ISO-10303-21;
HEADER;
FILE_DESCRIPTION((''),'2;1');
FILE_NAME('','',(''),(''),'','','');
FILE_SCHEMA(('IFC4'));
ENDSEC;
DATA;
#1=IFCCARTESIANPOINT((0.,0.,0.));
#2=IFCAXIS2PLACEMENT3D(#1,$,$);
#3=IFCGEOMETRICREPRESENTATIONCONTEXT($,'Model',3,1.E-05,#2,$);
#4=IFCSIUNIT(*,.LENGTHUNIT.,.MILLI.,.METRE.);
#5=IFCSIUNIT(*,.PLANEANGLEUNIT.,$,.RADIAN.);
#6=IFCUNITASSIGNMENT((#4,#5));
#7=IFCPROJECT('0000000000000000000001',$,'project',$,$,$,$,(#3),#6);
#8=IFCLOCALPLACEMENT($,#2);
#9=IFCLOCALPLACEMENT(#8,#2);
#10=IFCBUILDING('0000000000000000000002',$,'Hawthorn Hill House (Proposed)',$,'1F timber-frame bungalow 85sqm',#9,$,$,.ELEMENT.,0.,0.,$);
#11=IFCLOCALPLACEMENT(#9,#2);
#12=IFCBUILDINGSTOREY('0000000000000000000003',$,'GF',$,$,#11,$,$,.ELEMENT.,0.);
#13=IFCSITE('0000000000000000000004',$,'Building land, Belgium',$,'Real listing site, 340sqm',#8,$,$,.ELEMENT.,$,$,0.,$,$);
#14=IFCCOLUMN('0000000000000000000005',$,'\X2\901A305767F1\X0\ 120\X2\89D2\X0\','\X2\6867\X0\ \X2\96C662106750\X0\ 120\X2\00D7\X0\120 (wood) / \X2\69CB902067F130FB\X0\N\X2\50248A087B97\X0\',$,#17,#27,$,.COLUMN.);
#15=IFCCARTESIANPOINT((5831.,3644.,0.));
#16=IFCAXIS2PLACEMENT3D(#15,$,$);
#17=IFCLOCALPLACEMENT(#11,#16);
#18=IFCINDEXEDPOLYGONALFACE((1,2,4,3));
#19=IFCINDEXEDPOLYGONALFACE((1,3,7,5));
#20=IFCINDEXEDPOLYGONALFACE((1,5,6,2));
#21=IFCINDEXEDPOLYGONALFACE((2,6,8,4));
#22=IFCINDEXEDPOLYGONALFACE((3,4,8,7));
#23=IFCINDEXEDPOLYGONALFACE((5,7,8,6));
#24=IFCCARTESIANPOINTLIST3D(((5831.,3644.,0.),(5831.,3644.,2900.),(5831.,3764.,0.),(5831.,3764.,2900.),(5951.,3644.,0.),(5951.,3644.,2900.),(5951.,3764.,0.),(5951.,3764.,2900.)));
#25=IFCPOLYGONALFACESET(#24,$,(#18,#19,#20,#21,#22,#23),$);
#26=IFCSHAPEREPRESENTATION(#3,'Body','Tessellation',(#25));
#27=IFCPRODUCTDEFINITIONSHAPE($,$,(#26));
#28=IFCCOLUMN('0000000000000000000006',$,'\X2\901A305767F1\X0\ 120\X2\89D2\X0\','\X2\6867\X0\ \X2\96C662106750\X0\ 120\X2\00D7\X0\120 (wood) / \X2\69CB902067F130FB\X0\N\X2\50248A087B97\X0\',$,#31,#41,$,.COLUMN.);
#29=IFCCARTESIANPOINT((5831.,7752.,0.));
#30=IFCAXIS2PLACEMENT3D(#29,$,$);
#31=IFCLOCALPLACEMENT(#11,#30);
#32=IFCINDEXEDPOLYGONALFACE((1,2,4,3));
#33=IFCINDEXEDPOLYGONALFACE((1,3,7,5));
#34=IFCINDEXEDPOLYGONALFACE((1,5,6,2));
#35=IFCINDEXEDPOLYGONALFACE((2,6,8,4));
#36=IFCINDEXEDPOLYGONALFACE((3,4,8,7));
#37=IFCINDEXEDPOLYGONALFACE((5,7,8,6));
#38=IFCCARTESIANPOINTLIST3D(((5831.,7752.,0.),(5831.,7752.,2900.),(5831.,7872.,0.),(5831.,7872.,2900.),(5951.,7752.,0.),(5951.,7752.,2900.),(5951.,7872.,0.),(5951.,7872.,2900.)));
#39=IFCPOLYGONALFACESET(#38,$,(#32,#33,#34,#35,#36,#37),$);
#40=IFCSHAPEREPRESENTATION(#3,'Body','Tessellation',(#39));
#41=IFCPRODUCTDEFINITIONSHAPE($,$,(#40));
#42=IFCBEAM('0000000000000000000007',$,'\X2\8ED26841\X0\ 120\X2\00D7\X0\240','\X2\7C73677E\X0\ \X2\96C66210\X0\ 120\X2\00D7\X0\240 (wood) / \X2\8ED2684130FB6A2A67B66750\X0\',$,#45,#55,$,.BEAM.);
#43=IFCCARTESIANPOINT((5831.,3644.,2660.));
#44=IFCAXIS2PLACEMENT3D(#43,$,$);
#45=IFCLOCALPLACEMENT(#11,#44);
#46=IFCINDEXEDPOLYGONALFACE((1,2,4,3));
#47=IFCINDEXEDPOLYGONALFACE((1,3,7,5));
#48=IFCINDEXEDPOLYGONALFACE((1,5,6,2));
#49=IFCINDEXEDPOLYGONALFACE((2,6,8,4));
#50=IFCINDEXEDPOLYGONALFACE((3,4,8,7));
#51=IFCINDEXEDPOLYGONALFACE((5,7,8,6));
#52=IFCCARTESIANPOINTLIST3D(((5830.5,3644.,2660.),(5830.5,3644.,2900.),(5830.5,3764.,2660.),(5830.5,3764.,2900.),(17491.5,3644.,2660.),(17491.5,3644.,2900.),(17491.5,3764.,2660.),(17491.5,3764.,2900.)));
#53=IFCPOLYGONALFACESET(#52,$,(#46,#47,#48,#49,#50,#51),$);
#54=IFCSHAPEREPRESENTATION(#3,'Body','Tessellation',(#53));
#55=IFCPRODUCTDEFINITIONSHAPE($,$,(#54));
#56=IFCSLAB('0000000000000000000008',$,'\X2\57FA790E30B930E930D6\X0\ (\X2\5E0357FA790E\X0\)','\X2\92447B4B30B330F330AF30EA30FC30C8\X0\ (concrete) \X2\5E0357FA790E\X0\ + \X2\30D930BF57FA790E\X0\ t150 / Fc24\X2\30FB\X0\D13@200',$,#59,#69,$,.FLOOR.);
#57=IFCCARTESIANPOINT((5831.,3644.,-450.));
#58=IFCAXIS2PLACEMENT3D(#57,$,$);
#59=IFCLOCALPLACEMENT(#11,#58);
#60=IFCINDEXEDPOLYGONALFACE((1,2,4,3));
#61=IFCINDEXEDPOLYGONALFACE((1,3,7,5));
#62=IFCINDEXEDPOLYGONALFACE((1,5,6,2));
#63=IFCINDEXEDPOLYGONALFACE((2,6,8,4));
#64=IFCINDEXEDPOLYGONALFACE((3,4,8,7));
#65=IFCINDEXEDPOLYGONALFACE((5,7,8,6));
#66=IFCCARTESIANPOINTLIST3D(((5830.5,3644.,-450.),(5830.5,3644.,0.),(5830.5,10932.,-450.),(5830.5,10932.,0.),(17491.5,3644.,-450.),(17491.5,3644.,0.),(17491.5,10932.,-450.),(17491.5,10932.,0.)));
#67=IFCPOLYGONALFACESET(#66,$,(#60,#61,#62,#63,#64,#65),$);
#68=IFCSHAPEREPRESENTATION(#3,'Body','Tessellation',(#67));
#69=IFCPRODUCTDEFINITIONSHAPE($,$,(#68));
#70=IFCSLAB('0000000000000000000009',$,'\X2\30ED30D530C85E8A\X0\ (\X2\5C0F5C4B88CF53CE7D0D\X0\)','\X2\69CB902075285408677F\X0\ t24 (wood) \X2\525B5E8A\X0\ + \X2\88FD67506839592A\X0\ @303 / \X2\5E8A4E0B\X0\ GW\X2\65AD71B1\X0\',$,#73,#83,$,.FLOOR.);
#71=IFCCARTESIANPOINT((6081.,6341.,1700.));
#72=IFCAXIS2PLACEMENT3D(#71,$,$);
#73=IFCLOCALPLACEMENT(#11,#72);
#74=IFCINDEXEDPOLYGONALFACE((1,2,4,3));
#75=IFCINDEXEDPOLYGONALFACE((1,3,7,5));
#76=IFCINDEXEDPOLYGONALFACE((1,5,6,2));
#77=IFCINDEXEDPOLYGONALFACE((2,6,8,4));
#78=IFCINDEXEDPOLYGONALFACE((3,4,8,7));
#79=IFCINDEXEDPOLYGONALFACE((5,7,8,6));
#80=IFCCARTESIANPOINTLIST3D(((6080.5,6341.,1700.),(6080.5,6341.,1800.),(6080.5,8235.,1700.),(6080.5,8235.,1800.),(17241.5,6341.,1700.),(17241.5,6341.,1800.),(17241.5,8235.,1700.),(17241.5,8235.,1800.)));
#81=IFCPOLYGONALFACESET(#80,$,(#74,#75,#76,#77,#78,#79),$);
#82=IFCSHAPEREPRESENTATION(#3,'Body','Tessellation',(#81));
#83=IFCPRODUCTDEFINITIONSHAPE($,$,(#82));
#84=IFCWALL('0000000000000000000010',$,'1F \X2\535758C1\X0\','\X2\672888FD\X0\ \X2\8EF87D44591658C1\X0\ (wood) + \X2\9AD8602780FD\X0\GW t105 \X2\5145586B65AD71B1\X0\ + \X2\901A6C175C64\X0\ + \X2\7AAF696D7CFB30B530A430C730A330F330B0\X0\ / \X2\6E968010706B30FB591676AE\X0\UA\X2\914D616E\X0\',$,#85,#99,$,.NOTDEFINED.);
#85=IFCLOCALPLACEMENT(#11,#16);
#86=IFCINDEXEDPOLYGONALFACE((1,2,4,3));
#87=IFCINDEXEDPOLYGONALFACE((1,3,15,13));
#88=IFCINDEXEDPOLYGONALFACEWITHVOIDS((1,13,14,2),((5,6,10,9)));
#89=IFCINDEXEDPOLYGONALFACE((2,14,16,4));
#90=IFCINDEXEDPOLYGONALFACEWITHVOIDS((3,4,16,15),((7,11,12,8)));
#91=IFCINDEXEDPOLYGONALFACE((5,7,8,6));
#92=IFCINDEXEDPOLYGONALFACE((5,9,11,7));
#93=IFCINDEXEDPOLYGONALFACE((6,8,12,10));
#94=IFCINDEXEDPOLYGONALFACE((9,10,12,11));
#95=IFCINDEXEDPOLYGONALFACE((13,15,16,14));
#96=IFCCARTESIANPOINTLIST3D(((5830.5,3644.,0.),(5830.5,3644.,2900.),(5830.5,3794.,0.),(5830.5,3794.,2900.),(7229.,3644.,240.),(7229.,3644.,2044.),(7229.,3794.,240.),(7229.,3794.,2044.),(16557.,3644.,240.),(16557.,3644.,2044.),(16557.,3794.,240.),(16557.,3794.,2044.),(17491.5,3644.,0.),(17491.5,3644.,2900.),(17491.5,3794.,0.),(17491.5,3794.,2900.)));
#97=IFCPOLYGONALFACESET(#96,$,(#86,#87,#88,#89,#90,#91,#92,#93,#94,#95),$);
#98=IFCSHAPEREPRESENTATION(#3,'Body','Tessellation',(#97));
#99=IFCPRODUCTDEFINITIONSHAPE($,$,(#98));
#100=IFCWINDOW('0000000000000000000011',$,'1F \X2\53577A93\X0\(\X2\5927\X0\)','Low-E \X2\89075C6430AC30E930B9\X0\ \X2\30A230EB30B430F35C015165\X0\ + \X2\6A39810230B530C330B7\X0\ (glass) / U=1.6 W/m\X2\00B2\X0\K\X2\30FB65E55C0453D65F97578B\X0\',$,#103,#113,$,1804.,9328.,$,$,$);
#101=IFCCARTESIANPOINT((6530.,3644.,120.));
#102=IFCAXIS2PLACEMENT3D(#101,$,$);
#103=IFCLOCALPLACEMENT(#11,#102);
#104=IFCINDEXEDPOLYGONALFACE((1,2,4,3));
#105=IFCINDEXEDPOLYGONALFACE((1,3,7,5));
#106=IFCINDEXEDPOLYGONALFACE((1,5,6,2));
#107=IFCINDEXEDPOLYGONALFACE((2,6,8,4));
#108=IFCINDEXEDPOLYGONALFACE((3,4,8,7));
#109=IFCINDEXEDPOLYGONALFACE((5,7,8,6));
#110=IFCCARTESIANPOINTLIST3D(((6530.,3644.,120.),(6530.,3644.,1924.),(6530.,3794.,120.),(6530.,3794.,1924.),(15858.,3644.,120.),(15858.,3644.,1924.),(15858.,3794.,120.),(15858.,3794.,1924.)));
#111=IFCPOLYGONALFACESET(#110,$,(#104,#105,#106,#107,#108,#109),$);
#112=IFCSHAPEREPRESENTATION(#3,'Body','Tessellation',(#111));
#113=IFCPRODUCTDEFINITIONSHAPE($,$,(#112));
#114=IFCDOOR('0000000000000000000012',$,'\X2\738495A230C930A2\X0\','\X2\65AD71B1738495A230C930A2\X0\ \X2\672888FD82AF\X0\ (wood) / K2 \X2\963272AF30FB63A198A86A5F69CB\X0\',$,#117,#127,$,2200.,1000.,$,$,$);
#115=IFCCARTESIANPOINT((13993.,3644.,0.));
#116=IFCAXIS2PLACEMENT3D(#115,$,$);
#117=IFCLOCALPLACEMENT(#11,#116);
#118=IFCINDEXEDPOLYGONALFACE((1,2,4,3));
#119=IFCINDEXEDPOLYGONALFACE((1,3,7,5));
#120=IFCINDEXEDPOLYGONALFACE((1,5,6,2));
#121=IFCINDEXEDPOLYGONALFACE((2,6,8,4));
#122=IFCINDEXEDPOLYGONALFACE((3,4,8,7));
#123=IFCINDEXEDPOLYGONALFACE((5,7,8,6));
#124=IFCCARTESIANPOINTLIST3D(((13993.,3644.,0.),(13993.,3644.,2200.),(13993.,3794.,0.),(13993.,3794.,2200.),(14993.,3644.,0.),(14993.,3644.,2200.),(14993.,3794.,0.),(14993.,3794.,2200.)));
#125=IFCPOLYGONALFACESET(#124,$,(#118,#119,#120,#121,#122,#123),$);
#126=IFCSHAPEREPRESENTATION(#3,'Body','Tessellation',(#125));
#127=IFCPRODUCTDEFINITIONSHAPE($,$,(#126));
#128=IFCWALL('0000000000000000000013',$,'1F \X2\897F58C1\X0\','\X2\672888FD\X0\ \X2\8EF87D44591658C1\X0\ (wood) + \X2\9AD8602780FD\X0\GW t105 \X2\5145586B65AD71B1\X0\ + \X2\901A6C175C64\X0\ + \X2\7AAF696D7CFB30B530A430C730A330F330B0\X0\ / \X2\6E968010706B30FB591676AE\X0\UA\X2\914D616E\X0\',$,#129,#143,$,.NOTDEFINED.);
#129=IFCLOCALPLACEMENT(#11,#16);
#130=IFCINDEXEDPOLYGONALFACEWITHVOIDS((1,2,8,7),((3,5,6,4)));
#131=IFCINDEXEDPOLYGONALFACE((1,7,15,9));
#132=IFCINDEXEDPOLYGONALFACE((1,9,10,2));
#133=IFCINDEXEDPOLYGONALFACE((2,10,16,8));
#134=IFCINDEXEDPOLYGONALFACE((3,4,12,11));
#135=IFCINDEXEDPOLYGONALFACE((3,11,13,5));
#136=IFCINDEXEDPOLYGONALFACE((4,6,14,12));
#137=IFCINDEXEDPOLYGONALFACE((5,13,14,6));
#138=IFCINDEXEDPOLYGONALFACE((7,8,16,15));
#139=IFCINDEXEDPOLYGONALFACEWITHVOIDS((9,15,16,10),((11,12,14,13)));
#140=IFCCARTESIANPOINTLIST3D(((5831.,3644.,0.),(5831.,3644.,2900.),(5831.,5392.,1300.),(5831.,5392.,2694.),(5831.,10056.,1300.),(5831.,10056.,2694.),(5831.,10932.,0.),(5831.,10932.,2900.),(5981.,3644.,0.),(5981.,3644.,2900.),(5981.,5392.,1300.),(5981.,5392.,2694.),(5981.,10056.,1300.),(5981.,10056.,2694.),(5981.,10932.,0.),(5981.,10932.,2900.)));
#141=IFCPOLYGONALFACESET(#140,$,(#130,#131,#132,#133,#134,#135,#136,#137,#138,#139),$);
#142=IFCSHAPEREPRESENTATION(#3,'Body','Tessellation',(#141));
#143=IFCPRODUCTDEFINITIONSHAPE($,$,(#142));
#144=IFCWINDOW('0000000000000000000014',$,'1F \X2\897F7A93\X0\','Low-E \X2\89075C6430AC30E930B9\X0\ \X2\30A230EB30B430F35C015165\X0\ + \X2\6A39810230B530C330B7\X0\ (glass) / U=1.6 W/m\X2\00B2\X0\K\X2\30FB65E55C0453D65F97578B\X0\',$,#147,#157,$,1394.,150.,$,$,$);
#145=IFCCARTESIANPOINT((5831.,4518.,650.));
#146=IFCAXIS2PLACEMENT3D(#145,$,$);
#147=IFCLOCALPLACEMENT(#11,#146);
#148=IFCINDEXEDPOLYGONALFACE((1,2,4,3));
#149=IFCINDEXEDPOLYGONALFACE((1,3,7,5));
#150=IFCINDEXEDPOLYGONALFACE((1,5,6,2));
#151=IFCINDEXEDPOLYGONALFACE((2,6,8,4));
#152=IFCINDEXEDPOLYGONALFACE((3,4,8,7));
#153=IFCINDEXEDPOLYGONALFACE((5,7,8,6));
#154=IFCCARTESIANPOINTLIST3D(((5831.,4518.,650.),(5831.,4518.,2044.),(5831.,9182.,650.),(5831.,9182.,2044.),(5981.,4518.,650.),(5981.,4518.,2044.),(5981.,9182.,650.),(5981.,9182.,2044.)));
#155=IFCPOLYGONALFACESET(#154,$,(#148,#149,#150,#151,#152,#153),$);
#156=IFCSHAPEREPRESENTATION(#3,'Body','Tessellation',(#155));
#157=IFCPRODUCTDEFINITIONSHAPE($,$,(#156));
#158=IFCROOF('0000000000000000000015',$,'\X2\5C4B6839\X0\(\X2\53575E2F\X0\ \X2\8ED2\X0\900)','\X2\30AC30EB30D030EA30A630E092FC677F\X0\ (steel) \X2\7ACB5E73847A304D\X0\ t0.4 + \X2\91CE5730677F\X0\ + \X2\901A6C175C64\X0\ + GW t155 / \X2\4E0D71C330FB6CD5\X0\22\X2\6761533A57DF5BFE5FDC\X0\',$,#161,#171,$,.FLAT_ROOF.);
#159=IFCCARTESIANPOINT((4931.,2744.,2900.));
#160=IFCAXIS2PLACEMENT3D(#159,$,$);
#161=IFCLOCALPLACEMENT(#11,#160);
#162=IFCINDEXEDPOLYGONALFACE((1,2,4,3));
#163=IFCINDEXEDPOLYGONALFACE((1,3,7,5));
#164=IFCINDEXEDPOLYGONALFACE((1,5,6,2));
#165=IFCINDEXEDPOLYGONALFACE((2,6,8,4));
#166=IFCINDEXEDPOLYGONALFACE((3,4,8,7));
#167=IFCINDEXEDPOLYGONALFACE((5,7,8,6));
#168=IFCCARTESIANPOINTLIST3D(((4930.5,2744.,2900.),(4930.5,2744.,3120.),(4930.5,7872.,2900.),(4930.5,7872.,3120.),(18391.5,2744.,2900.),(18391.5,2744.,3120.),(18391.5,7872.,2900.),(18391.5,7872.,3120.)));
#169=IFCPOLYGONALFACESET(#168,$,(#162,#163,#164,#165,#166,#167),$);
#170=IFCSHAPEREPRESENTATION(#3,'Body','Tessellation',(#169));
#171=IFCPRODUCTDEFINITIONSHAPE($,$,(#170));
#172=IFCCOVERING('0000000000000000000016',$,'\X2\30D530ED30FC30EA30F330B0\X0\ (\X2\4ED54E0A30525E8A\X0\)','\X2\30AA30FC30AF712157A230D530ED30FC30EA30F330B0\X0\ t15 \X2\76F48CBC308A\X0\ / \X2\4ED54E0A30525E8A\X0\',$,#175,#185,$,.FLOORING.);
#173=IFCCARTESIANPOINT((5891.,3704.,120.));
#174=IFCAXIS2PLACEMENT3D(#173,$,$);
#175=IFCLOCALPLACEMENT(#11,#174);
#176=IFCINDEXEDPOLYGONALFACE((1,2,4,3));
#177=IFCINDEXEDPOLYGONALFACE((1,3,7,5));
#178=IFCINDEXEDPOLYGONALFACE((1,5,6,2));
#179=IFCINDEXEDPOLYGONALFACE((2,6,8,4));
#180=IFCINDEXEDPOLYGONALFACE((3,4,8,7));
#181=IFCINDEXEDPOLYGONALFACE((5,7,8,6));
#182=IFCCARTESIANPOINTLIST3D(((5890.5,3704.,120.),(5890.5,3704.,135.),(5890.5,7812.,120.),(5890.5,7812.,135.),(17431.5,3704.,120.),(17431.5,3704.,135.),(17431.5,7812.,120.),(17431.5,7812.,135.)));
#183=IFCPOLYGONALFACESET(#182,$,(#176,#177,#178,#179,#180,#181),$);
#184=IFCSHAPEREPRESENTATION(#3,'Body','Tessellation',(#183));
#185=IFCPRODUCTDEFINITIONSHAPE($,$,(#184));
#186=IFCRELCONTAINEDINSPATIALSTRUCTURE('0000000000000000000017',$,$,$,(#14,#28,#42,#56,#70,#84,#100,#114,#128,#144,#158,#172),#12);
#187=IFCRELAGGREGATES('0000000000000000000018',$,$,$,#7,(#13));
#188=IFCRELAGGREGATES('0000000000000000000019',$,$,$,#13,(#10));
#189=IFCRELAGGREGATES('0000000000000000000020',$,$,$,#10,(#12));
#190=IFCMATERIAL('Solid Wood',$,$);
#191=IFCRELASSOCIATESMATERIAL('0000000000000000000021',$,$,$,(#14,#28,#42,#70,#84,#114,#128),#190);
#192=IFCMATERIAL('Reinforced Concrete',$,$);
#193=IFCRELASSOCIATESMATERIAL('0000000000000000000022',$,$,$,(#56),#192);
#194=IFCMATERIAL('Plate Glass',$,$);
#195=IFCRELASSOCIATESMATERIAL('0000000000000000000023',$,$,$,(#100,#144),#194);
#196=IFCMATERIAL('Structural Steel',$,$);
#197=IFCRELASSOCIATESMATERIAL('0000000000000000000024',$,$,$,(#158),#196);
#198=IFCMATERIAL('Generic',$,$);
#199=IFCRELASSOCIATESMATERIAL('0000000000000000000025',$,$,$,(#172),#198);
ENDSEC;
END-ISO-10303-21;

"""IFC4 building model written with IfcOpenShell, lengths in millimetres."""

from ifc_helpers import new_model, si_unit, frame, frame_2d, origin, place, context, project, spatial, rectangle, extrude, material, element, fill, save


model = new_model("IFC4")

# Units and contexts
model_context = context("Model", 3, precision=1e-05, world=origin())
ifc_project = project(units=[si_unit("LENGTHUNIT", "METRE", prefix="MILLI"), si_unit("PLANEANGLEUNIT", "RADIAN")], contexts=[model_context])

# Site, building, storey
site_placement = place(None, origin())
site = spatial("IfcSite", under=ifc_project, at=site_placement, Name="Building land, Belgium", ObjectType="Real listing site, 340sqm", CompositionType="ELEMENT", RefElevation=0.0)
building_placement = place(site_placement, origin())
building = spatial("IfcBuilding", under=site, at=building_placement, Name="Hawthorn Hill House (Proposed)", ObjectType="1F timber-frame bungalow 85sqm", CompositionType="ELEMENT", ElevationOfRefHeight=0.0, ElevationOfTerrain=0.0)
storey_placement = place(building_placement, origin())
storey = spatial("IfcBuildingStorey", under=building, at=storey_placement, Name="GF", CompositionType="ELEMENT", Elevation=0.0)

# Columns
ifc_material_1 = material(Name="Solid Wood")
column_1_placement = place(storey_placement, frame((5831.0, 3644.0, 0.0)))
element("IfcColumn", 1, at=column_1_placement, inside=storey, material=ifc_material_1, Name="通し柱 120角", Description="桧 集成材 120×120 (wood) / 構造柱・N値計算", PredefinedType="COLUMN", context=model_context, shape_type="SweptSolid", body=[
    extrude(rectangle(XDim=120.0, YDim=120.0, at=frame_2d((60.0, 60.0))), frame((5831.0, 3644.0, 0.0)), (0.0, 0.0, 1.0), 2900.0),
])
column_2_placement = place(storey_placement, frame((5831.0, 7752.0, 0.0)))
element("IfcColumn", 2, at=column_2_placement, inside=storey, material=ifc_material_1, Name="通し柱 120角", Description="桧 集成材 120×120 (wood) / 構造柱・N値計算", PredefinedType="COLUMN", context=model_context, shape_type="SweptSolid", body=[
    extrude(rectangle(XDim=120.0, YDim=120.0, at=frame_2d((60.0, 60.0))), frame((5831.0, 7752.0, 0.0)), (0.0, 0.0, 1.0), 2900.0),
])

# Beam
beam_1_placement = place(storey_placement, frame((5831.0, 3644.0, 2660.0)))
element("IfcBeam", 3, at=beam_1_placement, inside=storey, material=ifc_material_1, Name="軒桁 120×240", Description="米松 集成 120×240 (wood) / 軒桁・横架材", PredefinedType="BEAM", context=model_context, shape_type="SweptSolid", body=[
    extrude(rectangle(XDim=11661.0, YDim=120.0, at=frame_2d((5830.0, 60.0))), frame((5831.0, 3644.0, 2660.0)), (0.0, 0.0, 1.0), 240.0),
])

# Slabs
ifc_material_2 = material(Name="Reinforced Concrete")
slab_1_placement = place(storey_placement, frame((5831.0, 3644.0, -450.0)))
element("IfcSlab", 4, at=slab_1_placement, inside=storey, material=ifc_material_2, Name="基礎スラブ (布基礎)", Description="鉄筋コンクリート (concrete) 布基礎 + ベタ基礎 t150 / Fc24・D13@200", PredefinedType="FLOOR", context=model_context, shape_type="SweptSolid", body=[
    extrude(rectangle(XDim=11661.0, YDim=7288.0, at=frame_2d((5830.0, 3644.0))), frame((5831.0, 3644.0, -450.0)), (0.0, 0.0, 1.0), 450.0),
])
slab_2_placement = place(storey_placement, frame((6081.0, 6341.0, 1700.0)))
element("IfcSlab", 5, at=slab_2_placement, inside=storey, material=ifc_material_1, Name="ロフト床 (小屋裏収納)", Description="構造用合板 t24 (wood) 剛床 + 製材根太 @303 / 床下 GW断熱", PredefinedType="FLOOR", context=model_context, shape_type="SweptSolid", body=[
    extrude(rectangle(XDim=11161.0, YDim=1894.0, at=frame_2d((5580.0, 947.0))), frame((6081.0, 6341.0, 1700.0)), (0.0, 0.0, 1.0), 100.0),
])

# Wall, openings, window, door
wall_1_placement = place(storey_placement, frame((5831.0, 3644.0, 0.0)))
wall_1 = element("IfcWall", 6, at=wall_1_placement, inside=storey, material=ifc_material_1, Name="1F 南壁", Description="木製 軸組外壁 (wood) + 高性能GW t105 充填断熱 + 通気層 + 窯業系サイディング / 準耐火・外皮UA配慮", PredefinedType="NOTDEFINED", context=model_context, shape_type="SweptSolid", body=[
    extrude(rectangle(XDim=11661.0, YDim=150.0, at=frame_2d((5830.0, 75.0))), frame((5831.0, 3644.0, 0.0)), (0.0, 0.0, 1.0), 2900.0),
])
opening_1_placement = place(storey_placement, frame((6530.0, 3644.0, 120.0)))
opening_1 = element("IfcOpeningElement", 7, at=opening_1_placement, cuts=wall_1, PredefinedType="NOTDEFINED", context=model_context, shape_type="SweptSolid", body=[
    extrude(rectangle(XDim=9328.0, YDim=150.0, at=frame_2d((4664.0, 75.0))), frame((6530.0, 3644.0, 120.0)), (0.0, 0.0, 1.0), 1804.0),
])
opening_2_placement = place(storey_placement, frame((13993.0, 3644.0, 0.0)))
opening_2 = element("IfcOpeningElement", 8, at=opening_2_placement, cuts=wall_1, PredefinedType="NOTDEFINED", context=model_context, shape_type="SweptSolid", body=[
    extrude(rectangle(XDim=1000.0, YDim=150.0, at=frame_2d((500.0, 75.0))), frame((13993.0, 3644.0, 0.0)), (0.0, 0.0, 1.0), 2200.0),
])
ifc_material_3 = material(Name="Plate Glass")
window_1_placement = place(storey_placement, frame((6530.0, 3644.0, 120.0)))
window_1 = element("IfcWindow", 9, at=window_1_placement, inside=storey, material=ifc_material_3, Name="1F 南窓(大)", Description="Low-E 複層ガラス アルゴン封入 + 樹脂サッシ (glass) / U=1.6 W/m²K・日射取得型", OverallHeight=1804.0, OverallWidth=9328.0, context=model_context, shape_type="SweptSolid", body=[
    extrude(rectangle(XDim=9328.0, YDim=150.0, at=frame_2d((4664.0, 75.0))), frame((6530.0, 3644.0, 120.0)), (0.0, 0.0, 1.0), 1804.0),
])
fill(opening_1, window_1)
door_placement = place(storey_placement, frame((13993.0, 3644.0, 0.0)))
door = element("IfcDoor", 10, at=door_placement, inside=storey, material=ifc_material_1, Name="玄関ドア", Description="断熱玄関ドア 木製芯 (wood) / K2 防犯・採風機構", OverallHeight=2200.0, OverallWidth=1000.0, context=model_context, shape_type="SweptSolid", body=[
    extrude(rectangle(XDim=1000.0, YDim=150.0, at=frame_2d((500.0, 75.0))), frame((13993.0, 3644.0, 0.0)), (0.0, 0.0, 1.0), 2200.0),
])
fill(opening_2, door)

# Wall, opening, window
wall_2_placement = place(storey_placement, frame((5831.0, 3644.0, 0.0)))
wall_2 = element("IfcWall", 11, at=wall_2_placement, inside=storey, material=ifc_material_1, Name="1F 西壁", Description="木製 軸組外壁 (wood) + 高性能GW t105 充填断熱 + 通気層 + 窯業系サイディング / 準耐火・外皮UA配慮", PredefinedType="NOTDEFINED", context=model_context, shape_type="SweptSolid", body=[
    extrude(rectangle(XDim=150.0, YDim=7288.0, at=frame_2d((75.0, 3644.0))), frame((5831.0, 3644.0, 0.0)), (0.0, 0.0, 1.0), 2900.0),
])
opening_3_placement = place(storey_placement, frame((5831.0, 4518.0, 650.0)))
opening_3 = element("IfcOpeningElement", 12, at=opening_3_placement, cuts=wall_2, PredefinedType="NOTDEFINED", context=model_context, shape_type="SweptSolid", body=[
    extrude(rectangle(XDim=150.0, YDim=4664.0, at=frame_2d((75.0, 2332.0))), frame((5831.0, 4518.0, 650.0)), (0.0, 0.0, 1.0), 1394.0),
])
window_2_placement = place(storey_placement, frame((5831.0, 4518.0, 650.0)))
window_2 = element("IfcWindow", 13, at=window_2_placement, inside=storey, material=ifc_material_3, Name="1F 西窓", Description="Low-E 複層ガラス アルゴン封入 + 樹脂サッシ (glass) / U=1.6 W/m²K・日射取得型", OverallHeight=1394.0, OverallWidth=150.0, context=model_context, shape_type="SweptSolid", body=[
    extrude(rectangle(XDim=150.0, YDim=4664.0, at=frame_2d((75.0, 2332.0))), frame((5831.0, 4518.0, 650.0)), (0.0, 0.0, 1.0), 1394.0),
])
fill(opening_3, window_2)

# Roof
ifc_material_4 = material(Name="Structural Steel")
roof_placement = place(storey_placement, frame((4931.0, 2744.0, 2900.0)))
element("IfcRoof", 14, at=roof_placement, inside=storey, material=ifc_material_4, Name="屋根(南帯 軒900)", Description="ガルバリウム鋼板 (steel) 立平葺き t0.4 + 野地板 + 通気層 + GW t155 / 不燃・法22条区域対応", PredefinedType="FLAT_ROOF", context=model_context, shape_type="SweptSolid", body=[
    extrude(rectangle(XDim=13461.0, YDim=5128.0, at=frame_2d((6730.0, 2564.0))), frame((4931.0, 2744.0, 2900.0)), (0.0, 0.0, 1.0), 220.0),
])

# Covering
ifc_material_5 = material(Name="Generic")
covering_1_placement = place(storey_placement, frame((5891.0, 3704.0, 120.0)))
element("IfcCovering", 15, at=covering_1_placement, inside=storey, material=ifc_material_5, Name="フローリング (仕上げ床)", Description="オーク無垢フローリング t15 直貼り / 仕上げ床", PredefinedType="FLOORING", context=model_context, shape_type="SweptSolid", body=[
    extrude(rectangle(XDim=11541.0, YDim=4108.0, at=frame_2d((5770.0, 2054.0))), frame((5891.0, 3704.0, 120.0)), (0.0, 0.0, 1.0), 15.0),
])

save(model, "model.ifc")
